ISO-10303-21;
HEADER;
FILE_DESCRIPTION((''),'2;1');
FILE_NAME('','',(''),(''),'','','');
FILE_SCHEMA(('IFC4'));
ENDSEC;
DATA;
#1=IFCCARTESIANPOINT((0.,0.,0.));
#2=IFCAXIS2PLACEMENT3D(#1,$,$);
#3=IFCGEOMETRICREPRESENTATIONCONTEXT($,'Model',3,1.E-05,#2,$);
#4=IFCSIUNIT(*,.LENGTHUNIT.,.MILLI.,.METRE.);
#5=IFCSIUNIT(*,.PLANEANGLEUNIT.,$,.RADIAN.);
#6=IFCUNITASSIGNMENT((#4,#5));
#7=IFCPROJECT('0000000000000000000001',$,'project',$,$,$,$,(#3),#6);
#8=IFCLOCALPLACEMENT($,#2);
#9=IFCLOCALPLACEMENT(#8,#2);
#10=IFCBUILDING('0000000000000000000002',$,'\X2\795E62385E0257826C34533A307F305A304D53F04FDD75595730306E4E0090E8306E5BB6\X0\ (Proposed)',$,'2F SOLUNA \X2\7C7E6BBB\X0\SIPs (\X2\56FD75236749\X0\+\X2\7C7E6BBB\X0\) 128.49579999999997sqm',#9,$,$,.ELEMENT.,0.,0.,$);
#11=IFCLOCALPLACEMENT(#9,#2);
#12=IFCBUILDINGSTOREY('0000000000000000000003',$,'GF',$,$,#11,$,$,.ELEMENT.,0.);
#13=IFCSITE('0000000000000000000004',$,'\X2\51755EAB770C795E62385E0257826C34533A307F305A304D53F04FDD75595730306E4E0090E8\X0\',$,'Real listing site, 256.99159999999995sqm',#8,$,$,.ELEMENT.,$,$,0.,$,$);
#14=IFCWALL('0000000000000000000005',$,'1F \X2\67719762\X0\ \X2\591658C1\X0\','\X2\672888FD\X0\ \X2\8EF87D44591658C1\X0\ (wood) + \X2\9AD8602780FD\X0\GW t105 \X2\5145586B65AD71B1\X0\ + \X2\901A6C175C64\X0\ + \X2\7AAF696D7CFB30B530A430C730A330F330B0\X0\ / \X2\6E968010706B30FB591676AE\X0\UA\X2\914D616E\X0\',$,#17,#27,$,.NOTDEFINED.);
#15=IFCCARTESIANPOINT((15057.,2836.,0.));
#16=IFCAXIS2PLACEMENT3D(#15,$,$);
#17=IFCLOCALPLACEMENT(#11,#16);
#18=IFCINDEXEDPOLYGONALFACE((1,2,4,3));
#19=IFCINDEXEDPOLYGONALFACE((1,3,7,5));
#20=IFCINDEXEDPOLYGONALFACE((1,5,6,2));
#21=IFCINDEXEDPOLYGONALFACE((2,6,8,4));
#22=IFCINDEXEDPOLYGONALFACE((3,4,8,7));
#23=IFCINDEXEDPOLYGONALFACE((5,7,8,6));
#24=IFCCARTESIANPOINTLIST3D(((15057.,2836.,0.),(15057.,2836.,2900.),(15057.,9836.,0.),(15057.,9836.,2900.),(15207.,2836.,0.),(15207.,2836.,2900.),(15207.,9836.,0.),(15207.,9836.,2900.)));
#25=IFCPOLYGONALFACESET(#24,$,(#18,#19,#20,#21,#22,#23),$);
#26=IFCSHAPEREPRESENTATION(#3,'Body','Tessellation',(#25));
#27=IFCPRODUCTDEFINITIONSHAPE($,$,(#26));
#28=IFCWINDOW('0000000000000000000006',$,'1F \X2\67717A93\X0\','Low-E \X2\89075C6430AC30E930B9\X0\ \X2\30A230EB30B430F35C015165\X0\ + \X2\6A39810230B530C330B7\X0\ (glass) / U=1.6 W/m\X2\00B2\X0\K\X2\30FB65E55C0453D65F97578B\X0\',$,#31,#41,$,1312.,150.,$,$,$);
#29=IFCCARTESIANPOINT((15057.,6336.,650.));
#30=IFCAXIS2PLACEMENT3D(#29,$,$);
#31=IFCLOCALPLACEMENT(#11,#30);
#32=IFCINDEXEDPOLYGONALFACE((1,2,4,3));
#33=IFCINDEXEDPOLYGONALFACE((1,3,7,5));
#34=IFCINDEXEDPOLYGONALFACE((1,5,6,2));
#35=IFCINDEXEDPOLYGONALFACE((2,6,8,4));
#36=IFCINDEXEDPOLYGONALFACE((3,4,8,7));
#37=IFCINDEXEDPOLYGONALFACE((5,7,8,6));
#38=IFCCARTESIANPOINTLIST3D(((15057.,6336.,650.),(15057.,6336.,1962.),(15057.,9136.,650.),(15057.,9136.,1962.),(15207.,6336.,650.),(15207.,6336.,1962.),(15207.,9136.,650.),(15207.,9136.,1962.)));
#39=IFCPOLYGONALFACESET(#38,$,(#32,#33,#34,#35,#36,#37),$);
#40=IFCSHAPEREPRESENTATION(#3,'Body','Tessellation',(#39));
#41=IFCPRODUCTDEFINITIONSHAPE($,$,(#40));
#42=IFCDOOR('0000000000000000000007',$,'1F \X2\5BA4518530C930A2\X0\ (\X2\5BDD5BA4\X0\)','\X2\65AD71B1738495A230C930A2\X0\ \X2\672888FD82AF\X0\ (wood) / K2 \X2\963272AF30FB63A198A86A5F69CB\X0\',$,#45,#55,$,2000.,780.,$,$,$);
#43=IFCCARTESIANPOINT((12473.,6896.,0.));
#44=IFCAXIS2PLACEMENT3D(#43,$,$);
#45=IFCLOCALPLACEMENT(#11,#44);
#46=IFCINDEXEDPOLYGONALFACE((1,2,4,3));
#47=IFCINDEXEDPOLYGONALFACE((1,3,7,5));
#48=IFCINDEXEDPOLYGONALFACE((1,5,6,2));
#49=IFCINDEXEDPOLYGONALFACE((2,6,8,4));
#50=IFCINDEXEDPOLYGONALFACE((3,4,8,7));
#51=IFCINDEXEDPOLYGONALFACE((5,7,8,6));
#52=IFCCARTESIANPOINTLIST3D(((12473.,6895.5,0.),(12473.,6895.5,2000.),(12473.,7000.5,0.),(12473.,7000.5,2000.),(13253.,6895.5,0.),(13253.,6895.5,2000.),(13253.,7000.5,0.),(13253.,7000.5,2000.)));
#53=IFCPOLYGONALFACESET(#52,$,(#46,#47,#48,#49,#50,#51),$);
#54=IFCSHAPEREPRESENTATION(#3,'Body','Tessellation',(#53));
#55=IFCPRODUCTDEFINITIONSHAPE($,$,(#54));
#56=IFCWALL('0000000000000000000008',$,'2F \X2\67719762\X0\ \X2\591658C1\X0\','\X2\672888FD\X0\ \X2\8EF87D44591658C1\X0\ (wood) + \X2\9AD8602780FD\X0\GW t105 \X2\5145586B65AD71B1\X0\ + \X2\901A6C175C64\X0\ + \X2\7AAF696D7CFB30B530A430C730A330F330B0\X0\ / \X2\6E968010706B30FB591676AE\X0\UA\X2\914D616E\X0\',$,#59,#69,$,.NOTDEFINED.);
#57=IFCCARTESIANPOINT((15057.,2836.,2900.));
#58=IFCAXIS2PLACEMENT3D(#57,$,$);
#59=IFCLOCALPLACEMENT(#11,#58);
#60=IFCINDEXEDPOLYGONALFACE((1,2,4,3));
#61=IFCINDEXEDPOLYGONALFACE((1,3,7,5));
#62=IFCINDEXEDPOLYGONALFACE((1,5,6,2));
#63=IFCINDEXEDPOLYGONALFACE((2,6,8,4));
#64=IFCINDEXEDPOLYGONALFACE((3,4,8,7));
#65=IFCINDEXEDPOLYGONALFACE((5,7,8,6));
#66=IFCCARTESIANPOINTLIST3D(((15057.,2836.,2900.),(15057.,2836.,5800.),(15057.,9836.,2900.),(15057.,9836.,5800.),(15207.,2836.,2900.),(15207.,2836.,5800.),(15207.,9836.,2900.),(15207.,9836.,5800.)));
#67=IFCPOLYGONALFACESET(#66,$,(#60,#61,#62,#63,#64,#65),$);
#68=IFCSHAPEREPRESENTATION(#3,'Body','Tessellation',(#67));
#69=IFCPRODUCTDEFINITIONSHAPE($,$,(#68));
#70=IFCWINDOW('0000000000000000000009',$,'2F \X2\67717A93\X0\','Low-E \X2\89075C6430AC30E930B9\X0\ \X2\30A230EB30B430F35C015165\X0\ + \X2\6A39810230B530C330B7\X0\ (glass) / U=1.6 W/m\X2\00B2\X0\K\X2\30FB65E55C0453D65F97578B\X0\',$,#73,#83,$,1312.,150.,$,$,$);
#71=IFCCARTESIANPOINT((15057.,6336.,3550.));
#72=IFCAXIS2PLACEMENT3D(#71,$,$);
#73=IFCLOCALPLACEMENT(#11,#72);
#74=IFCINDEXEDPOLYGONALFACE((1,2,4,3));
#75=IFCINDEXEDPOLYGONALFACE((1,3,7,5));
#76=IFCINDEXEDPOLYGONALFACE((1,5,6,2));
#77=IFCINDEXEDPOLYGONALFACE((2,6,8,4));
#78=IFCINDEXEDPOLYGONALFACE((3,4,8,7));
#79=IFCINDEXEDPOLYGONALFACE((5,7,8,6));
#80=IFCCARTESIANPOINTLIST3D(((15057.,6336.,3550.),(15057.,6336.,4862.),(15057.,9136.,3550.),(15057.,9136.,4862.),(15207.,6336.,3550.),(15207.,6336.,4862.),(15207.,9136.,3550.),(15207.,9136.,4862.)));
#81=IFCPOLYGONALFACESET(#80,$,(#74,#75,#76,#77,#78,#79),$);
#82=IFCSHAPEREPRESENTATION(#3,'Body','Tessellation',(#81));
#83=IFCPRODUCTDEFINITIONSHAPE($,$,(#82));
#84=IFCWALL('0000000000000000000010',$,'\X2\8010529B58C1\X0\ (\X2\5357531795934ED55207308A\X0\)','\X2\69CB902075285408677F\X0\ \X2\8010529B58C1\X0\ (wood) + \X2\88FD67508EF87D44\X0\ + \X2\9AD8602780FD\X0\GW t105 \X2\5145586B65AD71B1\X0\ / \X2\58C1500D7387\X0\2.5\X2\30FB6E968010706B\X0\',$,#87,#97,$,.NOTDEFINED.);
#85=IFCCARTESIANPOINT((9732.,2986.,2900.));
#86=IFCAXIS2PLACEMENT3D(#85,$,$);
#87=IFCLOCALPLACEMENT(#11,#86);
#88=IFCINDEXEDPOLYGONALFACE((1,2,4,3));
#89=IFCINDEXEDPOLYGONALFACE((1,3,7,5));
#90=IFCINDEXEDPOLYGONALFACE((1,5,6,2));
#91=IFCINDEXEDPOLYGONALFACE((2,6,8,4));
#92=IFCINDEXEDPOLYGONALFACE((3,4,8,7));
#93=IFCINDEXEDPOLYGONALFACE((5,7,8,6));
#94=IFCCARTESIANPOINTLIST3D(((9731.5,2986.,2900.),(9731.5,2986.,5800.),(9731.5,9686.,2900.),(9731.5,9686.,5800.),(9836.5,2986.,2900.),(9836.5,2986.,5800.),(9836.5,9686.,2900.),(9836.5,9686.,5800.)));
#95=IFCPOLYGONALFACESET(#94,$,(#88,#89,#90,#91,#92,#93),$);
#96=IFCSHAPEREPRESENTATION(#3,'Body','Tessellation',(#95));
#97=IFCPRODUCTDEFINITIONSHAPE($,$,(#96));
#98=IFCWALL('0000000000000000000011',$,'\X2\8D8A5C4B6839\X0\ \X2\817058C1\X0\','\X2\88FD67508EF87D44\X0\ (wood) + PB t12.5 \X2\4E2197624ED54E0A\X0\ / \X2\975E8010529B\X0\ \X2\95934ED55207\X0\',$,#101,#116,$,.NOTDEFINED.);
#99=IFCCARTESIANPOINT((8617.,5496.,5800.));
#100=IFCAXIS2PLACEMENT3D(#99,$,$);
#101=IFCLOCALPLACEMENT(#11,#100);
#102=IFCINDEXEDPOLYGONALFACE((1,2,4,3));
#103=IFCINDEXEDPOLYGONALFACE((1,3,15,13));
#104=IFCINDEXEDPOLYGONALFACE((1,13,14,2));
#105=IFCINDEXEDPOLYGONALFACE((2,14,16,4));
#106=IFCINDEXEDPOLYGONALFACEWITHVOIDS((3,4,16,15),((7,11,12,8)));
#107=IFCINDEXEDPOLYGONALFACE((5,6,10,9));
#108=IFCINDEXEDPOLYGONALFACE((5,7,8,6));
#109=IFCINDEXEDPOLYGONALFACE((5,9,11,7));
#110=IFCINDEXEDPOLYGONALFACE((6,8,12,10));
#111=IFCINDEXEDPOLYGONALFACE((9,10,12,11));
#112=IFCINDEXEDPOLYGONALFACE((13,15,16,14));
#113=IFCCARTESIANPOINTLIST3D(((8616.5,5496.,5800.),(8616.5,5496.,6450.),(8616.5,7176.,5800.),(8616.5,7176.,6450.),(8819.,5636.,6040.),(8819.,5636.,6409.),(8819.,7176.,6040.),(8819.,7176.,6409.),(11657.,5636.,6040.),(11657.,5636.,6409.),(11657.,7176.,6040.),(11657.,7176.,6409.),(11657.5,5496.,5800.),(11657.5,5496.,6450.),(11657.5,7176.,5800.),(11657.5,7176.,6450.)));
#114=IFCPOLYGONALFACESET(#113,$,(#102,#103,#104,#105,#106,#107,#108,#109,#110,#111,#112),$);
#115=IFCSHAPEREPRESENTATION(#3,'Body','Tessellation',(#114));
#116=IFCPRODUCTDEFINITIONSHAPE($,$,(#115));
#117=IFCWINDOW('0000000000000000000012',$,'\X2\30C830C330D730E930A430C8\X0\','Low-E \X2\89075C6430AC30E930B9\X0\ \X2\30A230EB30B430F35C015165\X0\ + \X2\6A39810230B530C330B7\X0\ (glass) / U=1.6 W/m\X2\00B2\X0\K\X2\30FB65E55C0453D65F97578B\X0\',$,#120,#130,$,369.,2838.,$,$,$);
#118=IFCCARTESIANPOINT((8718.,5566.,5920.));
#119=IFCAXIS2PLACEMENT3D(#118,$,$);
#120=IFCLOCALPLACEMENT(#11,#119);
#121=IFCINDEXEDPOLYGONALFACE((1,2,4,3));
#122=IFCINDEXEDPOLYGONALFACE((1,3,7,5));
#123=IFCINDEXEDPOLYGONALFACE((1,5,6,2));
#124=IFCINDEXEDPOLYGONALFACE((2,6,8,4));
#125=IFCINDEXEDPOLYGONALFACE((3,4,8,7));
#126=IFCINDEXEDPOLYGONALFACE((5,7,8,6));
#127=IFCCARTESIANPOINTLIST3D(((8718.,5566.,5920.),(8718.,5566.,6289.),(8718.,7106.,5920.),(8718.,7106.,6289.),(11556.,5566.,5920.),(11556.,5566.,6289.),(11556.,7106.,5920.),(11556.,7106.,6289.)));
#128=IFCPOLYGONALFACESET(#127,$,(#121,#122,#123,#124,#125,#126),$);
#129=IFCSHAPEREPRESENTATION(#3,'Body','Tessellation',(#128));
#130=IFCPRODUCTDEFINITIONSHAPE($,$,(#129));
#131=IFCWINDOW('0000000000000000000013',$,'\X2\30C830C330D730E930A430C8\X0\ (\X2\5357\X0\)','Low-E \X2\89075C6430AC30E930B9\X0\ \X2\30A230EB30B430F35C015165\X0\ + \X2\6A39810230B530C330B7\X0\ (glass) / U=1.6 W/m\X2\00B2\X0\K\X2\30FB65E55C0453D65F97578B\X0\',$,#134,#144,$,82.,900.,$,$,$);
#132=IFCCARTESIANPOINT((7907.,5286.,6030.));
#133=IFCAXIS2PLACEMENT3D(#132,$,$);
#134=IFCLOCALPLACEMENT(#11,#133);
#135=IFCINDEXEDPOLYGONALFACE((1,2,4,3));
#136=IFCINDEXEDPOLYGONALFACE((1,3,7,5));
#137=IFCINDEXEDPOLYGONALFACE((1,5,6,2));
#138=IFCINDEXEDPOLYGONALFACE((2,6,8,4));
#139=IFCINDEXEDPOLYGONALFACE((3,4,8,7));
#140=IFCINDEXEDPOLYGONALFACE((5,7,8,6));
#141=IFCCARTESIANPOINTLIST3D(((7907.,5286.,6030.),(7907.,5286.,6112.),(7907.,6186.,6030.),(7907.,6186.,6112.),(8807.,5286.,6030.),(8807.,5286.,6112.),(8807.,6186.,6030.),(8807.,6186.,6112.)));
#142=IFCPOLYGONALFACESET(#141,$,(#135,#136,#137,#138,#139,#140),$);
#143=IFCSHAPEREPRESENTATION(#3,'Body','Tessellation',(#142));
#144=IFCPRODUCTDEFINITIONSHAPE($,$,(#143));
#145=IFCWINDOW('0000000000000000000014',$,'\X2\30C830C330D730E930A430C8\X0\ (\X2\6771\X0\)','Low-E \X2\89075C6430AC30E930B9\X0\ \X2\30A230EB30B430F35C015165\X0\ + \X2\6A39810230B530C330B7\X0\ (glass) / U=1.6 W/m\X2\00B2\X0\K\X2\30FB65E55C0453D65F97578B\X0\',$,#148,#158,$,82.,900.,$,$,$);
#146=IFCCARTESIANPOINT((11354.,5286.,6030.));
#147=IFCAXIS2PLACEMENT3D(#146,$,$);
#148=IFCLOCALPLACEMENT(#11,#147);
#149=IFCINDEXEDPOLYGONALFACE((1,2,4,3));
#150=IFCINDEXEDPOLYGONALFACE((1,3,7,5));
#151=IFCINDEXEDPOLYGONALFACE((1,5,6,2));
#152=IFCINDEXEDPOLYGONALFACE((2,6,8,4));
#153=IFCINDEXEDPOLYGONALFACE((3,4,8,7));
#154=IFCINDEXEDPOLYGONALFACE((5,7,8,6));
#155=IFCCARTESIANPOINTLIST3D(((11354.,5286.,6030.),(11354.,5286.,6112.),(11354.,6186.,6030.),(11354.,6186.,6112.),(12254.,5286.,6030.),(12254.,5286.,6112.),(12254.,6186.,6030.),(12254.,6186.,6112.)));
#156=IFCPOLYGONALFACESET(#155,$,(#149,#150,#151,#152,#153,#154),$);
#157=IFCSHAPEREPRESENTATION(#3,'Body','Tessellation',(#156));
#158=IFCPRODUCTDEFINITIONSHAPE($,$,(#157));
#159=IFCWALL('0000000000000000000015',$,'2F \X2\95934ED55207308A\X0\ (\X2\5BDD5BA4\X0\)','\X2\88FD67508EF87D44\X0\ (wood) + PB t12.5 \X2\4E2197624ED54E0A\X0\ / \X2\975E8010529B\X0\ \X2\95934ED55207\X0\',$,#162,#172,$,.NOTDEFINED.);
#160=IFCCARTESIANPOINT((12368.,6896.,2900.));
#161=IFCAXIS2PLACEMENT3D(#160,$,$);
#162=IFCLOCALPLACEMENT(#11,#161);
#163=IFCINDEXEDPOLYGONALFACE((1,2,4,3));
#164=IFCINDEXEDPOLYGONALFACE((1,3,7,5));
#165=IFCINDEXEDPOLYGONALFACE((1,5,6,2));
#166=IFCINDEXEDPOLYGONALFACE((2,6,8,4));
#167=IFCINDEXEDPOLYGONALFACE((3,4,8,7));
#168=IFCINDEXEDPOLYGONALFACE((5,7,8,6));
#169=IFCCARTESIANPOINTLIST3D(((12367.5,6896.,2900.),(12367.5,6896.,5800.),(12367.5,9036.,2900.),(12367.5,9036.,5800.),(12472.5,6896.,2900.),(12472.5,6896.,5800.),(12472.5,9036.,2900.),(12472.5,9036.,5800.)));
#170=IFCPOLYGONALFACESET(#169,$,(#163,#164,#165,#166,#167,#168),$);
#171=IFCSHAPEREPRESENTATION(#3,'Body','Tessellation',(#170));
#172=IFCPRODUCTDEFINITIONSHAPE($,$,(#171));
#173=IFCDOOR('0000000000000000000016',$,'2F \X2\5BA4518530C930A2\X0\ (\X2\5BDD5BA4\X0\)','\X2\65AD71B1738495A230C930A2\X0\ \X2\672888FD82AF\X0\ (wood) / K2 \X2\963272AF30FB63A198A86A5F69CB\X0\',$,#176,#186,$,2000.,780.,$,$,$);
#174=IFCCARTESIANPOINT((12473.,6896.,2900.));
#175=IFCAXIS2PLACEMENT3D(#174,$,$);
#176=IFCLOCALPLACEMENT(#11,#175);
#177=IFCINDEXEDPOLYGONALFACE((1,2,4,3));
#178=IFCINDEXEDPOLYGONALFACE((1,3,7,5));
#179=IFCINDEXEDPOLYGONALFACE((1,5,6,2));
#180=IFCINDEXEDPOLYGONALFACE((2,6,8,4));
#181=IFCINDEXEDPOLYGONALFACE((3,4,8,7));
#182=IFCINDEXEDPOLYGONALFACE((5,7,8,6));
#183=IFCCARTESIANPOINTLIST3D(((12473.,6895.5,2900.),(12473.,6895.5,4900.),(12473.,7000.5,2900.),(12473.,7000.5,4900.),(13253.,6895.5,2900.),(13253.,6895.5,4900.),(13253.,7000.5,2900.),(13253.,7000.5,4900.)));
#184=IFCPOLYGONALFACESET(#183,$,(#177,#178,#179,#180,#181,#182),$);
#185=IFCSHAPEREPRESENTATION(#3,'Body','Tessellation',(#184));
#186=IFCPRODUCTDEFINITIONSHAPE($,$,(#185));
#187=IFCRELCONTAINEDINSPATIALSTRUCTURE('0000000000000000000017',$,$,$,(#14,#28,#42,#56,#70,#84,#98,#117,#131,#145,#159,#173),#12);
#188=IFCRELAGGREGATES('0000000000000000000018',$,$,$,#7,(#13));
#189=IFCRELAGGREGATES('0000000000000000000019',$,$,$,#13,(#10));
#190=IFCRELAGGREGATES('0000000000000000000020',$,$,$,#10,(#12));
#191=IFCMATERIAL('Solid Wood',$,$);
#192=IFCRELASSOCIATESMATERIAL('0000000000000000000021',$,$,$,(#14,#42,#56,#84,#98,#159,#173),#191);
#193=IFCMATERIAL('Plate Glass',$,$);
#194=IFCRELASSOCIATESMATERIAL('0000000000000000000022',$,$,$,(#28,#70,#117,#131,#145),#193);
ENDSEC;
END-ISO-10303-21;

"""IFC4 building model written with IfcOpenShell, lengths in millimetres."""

from ifc_helpers import new_model, si_unit, frame, frame_2d, origin, place, context, project, spatial, rectangle, extrude, material, element, fill, save


model = new_model("IFC4")

# Units and contexts
model_context = context("Model", 3, precision=1e-05, world=origin())
ifc_project = project(units=[si_unit("LENGTHUNIT", "METRE", prefix="MILLI"), si_unit("PLANEANGLEUNIT", "RADIAN")], contexts=[model_context])

# Site, building, storey
site_placement = place(None, origin())
site = spatial("IfcSite", under=ifc_project, at=site_placement, Name="兵庫県神戸市垂水区みずき台保留地の一部", ObjectType="Real listing site, 256.99159999999995sqm", CompositionType="ELEMENT", RefElevation=0.0)
building_placement = place(site_placement, origin())
building = spatial("IfcBuilding", under=site, at=building_placement, Name="神戸市垂水区みずき台保留地の一部の家 (Proposed)", ObjectType="2F SOLUNA 籾殻SIPs (国産杉+籾殻) 128.49579999999997sqm", CompositionType="ELEMENT", ElevationOfRefHeight=0.0, ElevationOfTerrain=0.0)
storey_placement = place(building_placement, origin())
storey = spatial("IfcBuildingStorey", under=building, at=storey_placement, Name="GF", CompositionType="ELEMENT", Elevation=0.0)

# Wall, opening, window
ifc_material_1 = material(Name="Solid Wood")
wall_1_placement = place(storey_placement, frame((15057.0, 2836.0, 0.0)))
wall_1 = element("IfcWall", 1, at=wall_1_placement, inside=storey, material=ifc_material_1, Name="1F 東面 外壁", Description="木製 軸組外壁 (wood) + 高性能GW t105 充填断熱 + 通気層 + 窯業系サイディング / 準耐火・外皮UA配慮", PredefinedType="NOTDEFINED", context=model_context, shape_type="SweptSolid", body=[
    extrude(rectangle(XDim=150.0, YDim=7000.0, at=frame_2d((75.0, 3500.0))), frame((15057.0, 2836.0, 0.0)), (0.0, 0.0, 1.0), 2900.0),
])
opening_1_placement = place(storey_placement, frame((15057.0, 6336.0, 650.0)))
opening_1 = element("IfcOpeningElement", 2, at=opening_1_placement, cuts=wall_1, PredefinedType="NOTDEFINED", context=model_context, shape_type="SweptSolid", body=[
    extrude(rectangle(XDim=150.0, YDim=2800.0, at=frame_2d((75.0, 1400.0))), frame((15057.0, 6336.0, 650.0)), (0.0, 0.0, 1.0), 1312.0),
])
ifc_material_2 = material(Name="Plate Glass")
window_1_placement = place(storey_placement, frame((15057.0, 6336.0, 650.0)))
window_1 = element("IfcWindow", 3, at=window_1_placement, inside=storey, material=ifc_material_2, Name="1F 東窓", Description="Low-E 複層ガラス アルゴン封入 + 樹脂サッシ (glass) / U=1.6 W/m²K・日射取得型", OverallHeight=1312.0, OverallWidth=150.0, context=model_context, shape_type="SweptSolid", body=[
    extrude(rectangle(XDim=150.0, YDim=2800.0, at=frame_2d((75.0, 1400.0))), frame((15057.0, 6336.0, 650.0)), (0.0, 0.0, 1.0), 1312.0),
])
fill(opening_1, window_1)

# Door
door_1_placement = place(storey_placement, frame((12473.0, 6896.0, 0.0)))
element("IfcDoor", 4, at=door_1_placement, inside=storey, material=ifc_material_1, Name="1F 室内ドア (寝室)", Description="断熱玄関ドア 木製芯 (wood) / K2 防犯・採風機構", OverallHeight=2000.0, OverallWidth=780.0, context=model_context, shape_type="SweptSolid", body=[
    extrude(rectangle(XDim=780.0, YDim=105.0, at=frame_2d((390.0, 52.0))), frame((12473.0, 6896.0, 0.0)), (0.0, 0.0, 1.0), 2000.0),
])

# Wall, opening, window
wall_2_placement = place(storey_placement, frame((15057.0, 2836.0, 2900.0)))
wall_2 = element("IfcWall", 5, at=wall_2_placement, inside=storey, material=ifc_material_1, Name="2F 東面 外壁", Description="木製 軸組外壁 (wood) + 高性能GW t105 充填断熱 + 通気層 + 窯業系サイディング / 準耐火・外皮UA配慮", PredefinedType="NOTDEFINED", context=model_context, shape_type="SweptSolid", body=[
    extrude(rectangle(XDim=150.0, YDim=7000.0, at=frame_2d((75.0, 3500.0))), frame((15057.0, 2836.0, 2900.0)), (0.0, 0.0, 1.0), 2900.0),
])
opening_2_placement = place(storey_placement, frame((15057.0, 6336.0, 3550.0)))
opening_2 = element("IfcOpeningElement", 6, at=opening_2_placement, cuts=wall_2, PredefinedType="NOTDEFINED", context=model_context, shape_type="SweptSolid", body=[
    extrude(rectangle(XDim=150.0, YDim=2800.0, at=frame_2d((75.0, 1400.0))), frame((15057.0, 6336.0, 3550.0)), (0.0, 0.0, 1.0), 1312.0),
])
window_2_placement = place(storey_placement, frame((15057.0, 6336.0, 3550.0)))
window_2 = element("IfcWindow", 7, at=window_2_placement, inside=storey, material=ifc_material_2, Name="2F 東窓", Description="Low-E 複層ガラス アルゴン封入 + 樹脂サッシ (glass) / U=1.6 W/m²K・日射取得型", OverallHeight=1312.0, OverallWidth=150.0, context=model_context, shape_type="SweptSolid", body=[
    extrude(rectangle(XDim=150.0, YDim=2800.0, at=frame_2d((75.0, 1400.0))), frame((15057.0, 6336.0, 3550.0)), (0.0, 0.0, 1.0), 1312.0),
])
fill(opening_2, window_2)

# Wall
wall_3_placement = place(storey_placement, frame((9732.0, 2986.0, 2900.0)))
element("IfcWall", 8, at=wall_3_placement, inside=storey, material=ifc_material_1, Name="耐力壁 (南北間仕切り)", Description="構造用合板 耐力壁 (wood) + 製材軸組 + 高性能GW t105 充填断熱 / 壁倍率2.5・準耐火", PredefinedType="NOTDEFINED", context=model_context, shape_type="SweptSolid", body=[
    extrude(rectangle(XDim=105.0, YDim=6700.0, at=frame_2d((52.0, 3350.0))), frame((9732.0, 2986.0, 2900.0)), (0.0, 0.0, 1.0), 2900.0),
])

# Wall, openings, windows
wall_4_placement = place(storey_placement, frame((8617.0, 5496.0, 5800.0)))
wall_4 = element("IfcWall", 9, at=wall_4_placement, inside=storey, material=ifc_material_1, Name="越屋根 腰壁", Description="製材軸組 (wood) + PB t12.5 両面仕上 / 非耐力 間仕切", PredefinedType="NOTDEFINED", context=model_context, shape_type="SweptSolid", body=[
    extrude(rectangle(XDim=3041.0, YDim=1680.0, at=frame_2d((1520.0, 840.0))), frame((8617.0, 5496.0, 5800.0)), (0.0, 0.0, 1.0), 650.0),
])
opening_3_placement = place(storey_placement, frame((8718.0, 5566.0, 5920.0)))
opening_3 = element("IfcOpeningElement", 10, at=opening_3_placement, cuts=wall_4, PredefinedType="NOTDEFINED", context=model_context, shape_type="SweptSolid", body=[
    extrude(rectangle(XDim=2838.0, YDim=1540.0, at=frame_2d((1419.0, 770.0))), frame((8718.0, 5566.0, 5920.0)), (0.0, 0.0, 1.0), 369.0),
])
opening_4_placement = place(storey_placement, frame((7907.0, 5286.0, 6030.0)))
opening_4 = element("IfcOpeningElement", 11, at=opening_4_placement, cuts=wall_4, PredefinedType="NOTDEFINED", context=model_context, shape_type="SweptSolid", body=[
    extrude(rectangle(XDim=900.0, YDim=900.0, at=frame_2d((450.0, 450.0))), frame((7907.0, 5286.0, 6030.0)), (0.0, 0.0, 1.0), 82.0),
])
opening_5_placement = place(storey_placement, frame((11354.0, 5286.0, 6030.0)))
opening_5 = element("IfcOpeningElement", 12, at=opening_5_placement, cuts=wall_4, PredefinedType="NOTDEFINED", context=model_context, shape_type="SweptSolid", body=[
    extrude(rectangle(XDim=900.0, YDim=900.0, at=frame_2d((450.0, 450.0))), frame((11354.0, 5286.0, 6030.0)), (0.0, 0.0, 1.0), 82.0),
])
window_3_placement = place(storey_placement, frame((8718.0, 5566.0, 5920.0)))
window_3 = element("IfcWindow", 13, at=window_3_placement, inside=storey, material=ifc_material_2, Name="トップライト", Description="Low-E 複層ガラス アルゴン封入 + 樹脂サッシ (glass) / U=1.6 W/m²K・日射取得型", OverallHeight=369.0, OverallWidth=2838.0, context=model_context, shape_type="SweptSolid", body=[
    extrude(rectangle(XDim=2838.0, YDim=1540.0, at=frame_2d((1419.0, 770.0))), frame((8718.0, 5566.0, 5920.0)), (0.0, 0.0, 1.0), 369.0),
])
fill(opening_3, window_3)
window_4_placement = place(storey_placement, frame((7907.0, 5286.0, 6030.0)))
window_4 = element("IfcWindow", 14, at=window_4_placement, inside=storey, material=ifc_material_2, Name="トップライト (南)", Description="Low-E 複層ガラス アルゴン封入 + 樹脂サッシ (glass) / U=1.6 W/m²K・日射取得型", OverallHeight=82.0, OverallWidth=900.0, context=model_context, shape_type="SweptSolid", body=[
    extrude(rectangle(XDim=900.0, YDim=900.0, at=frame_2d((450.0, 450.0))), frame((7907.0, 5286.0, 6030.0)), (0.0, 0.0, 1.0), 82.0),
])
fill(opening_4, window_4)
window_5_placement = place(storey_placement, frame((11354.0, 5286.0, 6030.0)))
window_5 = element("IfcWindow", 15, at=window_5_placement, inside=storey, material=ifc_material_2, Name="トップライト (東)", Description="Low-E 複層ガラス アルゴン封入 + 樹脂サッシ (glass) / U=1.6 W/m²K・日射取得型", OverallHeight=82.0, OverallWidth=900.0, context=model_context, shape_type="SweptSolid", body=[
    extrude(rectangle(XDim=900.0, YDim=900.0, at=frame_2d((450.0, 450.0))), frame((11354.0, 5286.0, 6030.0)), (0.0, 0.0, 1.0), 82.0),
])
fill(opening_5, window_5)

# Wall
wall_5_placement = place(storey_placement, frame((12368.0, 6896.0, 2900.0)))
element("IfcWall", 16, at=wall_5_placement, inside=storey, material=ifc_material_1, Name="2F 間仕切り (寝室)", Description="製材軸組 (wood) + PB t12.5 両面仕上 / 非耐力 間仕切", PredefinedType="NOTDEFINED", context=model_context, shape_type="SweptSolid", body=[
    extrude(rectangle(XDim=105.0, YDim=2140.0, at=frame_2d((52.0, 1070.0))), frame((12368.0, 6896.0, 2900.0)), (0.0, 0.0, 1.0), 2900.0),
])

# Door
door_2_placement = place(storey_placement, frame((12473.0, 6896.0, 2900.0)))
element("IfcDoor", 17, at=door_2_placement, inside=storey, material=ifc_material_1, Name="2F 室内ドア (寝室)", Description="断熱玄関ドア 木製芯 (wood) / K2 防犯・採風機構", OverallHeight=2000.0, OverallWidth=780.0, context=model_context, shape_type="SweptSolid", body=[
    extrude(rectangle(XDim=780.0, YDim=105.0, at=frame_2d((390.0, 52.0))), frame((12473.0, 6896.0, 2900.0)), (0.0, 0.0, 1.0), 2000.0),
])

save(model, "model.ifc")
